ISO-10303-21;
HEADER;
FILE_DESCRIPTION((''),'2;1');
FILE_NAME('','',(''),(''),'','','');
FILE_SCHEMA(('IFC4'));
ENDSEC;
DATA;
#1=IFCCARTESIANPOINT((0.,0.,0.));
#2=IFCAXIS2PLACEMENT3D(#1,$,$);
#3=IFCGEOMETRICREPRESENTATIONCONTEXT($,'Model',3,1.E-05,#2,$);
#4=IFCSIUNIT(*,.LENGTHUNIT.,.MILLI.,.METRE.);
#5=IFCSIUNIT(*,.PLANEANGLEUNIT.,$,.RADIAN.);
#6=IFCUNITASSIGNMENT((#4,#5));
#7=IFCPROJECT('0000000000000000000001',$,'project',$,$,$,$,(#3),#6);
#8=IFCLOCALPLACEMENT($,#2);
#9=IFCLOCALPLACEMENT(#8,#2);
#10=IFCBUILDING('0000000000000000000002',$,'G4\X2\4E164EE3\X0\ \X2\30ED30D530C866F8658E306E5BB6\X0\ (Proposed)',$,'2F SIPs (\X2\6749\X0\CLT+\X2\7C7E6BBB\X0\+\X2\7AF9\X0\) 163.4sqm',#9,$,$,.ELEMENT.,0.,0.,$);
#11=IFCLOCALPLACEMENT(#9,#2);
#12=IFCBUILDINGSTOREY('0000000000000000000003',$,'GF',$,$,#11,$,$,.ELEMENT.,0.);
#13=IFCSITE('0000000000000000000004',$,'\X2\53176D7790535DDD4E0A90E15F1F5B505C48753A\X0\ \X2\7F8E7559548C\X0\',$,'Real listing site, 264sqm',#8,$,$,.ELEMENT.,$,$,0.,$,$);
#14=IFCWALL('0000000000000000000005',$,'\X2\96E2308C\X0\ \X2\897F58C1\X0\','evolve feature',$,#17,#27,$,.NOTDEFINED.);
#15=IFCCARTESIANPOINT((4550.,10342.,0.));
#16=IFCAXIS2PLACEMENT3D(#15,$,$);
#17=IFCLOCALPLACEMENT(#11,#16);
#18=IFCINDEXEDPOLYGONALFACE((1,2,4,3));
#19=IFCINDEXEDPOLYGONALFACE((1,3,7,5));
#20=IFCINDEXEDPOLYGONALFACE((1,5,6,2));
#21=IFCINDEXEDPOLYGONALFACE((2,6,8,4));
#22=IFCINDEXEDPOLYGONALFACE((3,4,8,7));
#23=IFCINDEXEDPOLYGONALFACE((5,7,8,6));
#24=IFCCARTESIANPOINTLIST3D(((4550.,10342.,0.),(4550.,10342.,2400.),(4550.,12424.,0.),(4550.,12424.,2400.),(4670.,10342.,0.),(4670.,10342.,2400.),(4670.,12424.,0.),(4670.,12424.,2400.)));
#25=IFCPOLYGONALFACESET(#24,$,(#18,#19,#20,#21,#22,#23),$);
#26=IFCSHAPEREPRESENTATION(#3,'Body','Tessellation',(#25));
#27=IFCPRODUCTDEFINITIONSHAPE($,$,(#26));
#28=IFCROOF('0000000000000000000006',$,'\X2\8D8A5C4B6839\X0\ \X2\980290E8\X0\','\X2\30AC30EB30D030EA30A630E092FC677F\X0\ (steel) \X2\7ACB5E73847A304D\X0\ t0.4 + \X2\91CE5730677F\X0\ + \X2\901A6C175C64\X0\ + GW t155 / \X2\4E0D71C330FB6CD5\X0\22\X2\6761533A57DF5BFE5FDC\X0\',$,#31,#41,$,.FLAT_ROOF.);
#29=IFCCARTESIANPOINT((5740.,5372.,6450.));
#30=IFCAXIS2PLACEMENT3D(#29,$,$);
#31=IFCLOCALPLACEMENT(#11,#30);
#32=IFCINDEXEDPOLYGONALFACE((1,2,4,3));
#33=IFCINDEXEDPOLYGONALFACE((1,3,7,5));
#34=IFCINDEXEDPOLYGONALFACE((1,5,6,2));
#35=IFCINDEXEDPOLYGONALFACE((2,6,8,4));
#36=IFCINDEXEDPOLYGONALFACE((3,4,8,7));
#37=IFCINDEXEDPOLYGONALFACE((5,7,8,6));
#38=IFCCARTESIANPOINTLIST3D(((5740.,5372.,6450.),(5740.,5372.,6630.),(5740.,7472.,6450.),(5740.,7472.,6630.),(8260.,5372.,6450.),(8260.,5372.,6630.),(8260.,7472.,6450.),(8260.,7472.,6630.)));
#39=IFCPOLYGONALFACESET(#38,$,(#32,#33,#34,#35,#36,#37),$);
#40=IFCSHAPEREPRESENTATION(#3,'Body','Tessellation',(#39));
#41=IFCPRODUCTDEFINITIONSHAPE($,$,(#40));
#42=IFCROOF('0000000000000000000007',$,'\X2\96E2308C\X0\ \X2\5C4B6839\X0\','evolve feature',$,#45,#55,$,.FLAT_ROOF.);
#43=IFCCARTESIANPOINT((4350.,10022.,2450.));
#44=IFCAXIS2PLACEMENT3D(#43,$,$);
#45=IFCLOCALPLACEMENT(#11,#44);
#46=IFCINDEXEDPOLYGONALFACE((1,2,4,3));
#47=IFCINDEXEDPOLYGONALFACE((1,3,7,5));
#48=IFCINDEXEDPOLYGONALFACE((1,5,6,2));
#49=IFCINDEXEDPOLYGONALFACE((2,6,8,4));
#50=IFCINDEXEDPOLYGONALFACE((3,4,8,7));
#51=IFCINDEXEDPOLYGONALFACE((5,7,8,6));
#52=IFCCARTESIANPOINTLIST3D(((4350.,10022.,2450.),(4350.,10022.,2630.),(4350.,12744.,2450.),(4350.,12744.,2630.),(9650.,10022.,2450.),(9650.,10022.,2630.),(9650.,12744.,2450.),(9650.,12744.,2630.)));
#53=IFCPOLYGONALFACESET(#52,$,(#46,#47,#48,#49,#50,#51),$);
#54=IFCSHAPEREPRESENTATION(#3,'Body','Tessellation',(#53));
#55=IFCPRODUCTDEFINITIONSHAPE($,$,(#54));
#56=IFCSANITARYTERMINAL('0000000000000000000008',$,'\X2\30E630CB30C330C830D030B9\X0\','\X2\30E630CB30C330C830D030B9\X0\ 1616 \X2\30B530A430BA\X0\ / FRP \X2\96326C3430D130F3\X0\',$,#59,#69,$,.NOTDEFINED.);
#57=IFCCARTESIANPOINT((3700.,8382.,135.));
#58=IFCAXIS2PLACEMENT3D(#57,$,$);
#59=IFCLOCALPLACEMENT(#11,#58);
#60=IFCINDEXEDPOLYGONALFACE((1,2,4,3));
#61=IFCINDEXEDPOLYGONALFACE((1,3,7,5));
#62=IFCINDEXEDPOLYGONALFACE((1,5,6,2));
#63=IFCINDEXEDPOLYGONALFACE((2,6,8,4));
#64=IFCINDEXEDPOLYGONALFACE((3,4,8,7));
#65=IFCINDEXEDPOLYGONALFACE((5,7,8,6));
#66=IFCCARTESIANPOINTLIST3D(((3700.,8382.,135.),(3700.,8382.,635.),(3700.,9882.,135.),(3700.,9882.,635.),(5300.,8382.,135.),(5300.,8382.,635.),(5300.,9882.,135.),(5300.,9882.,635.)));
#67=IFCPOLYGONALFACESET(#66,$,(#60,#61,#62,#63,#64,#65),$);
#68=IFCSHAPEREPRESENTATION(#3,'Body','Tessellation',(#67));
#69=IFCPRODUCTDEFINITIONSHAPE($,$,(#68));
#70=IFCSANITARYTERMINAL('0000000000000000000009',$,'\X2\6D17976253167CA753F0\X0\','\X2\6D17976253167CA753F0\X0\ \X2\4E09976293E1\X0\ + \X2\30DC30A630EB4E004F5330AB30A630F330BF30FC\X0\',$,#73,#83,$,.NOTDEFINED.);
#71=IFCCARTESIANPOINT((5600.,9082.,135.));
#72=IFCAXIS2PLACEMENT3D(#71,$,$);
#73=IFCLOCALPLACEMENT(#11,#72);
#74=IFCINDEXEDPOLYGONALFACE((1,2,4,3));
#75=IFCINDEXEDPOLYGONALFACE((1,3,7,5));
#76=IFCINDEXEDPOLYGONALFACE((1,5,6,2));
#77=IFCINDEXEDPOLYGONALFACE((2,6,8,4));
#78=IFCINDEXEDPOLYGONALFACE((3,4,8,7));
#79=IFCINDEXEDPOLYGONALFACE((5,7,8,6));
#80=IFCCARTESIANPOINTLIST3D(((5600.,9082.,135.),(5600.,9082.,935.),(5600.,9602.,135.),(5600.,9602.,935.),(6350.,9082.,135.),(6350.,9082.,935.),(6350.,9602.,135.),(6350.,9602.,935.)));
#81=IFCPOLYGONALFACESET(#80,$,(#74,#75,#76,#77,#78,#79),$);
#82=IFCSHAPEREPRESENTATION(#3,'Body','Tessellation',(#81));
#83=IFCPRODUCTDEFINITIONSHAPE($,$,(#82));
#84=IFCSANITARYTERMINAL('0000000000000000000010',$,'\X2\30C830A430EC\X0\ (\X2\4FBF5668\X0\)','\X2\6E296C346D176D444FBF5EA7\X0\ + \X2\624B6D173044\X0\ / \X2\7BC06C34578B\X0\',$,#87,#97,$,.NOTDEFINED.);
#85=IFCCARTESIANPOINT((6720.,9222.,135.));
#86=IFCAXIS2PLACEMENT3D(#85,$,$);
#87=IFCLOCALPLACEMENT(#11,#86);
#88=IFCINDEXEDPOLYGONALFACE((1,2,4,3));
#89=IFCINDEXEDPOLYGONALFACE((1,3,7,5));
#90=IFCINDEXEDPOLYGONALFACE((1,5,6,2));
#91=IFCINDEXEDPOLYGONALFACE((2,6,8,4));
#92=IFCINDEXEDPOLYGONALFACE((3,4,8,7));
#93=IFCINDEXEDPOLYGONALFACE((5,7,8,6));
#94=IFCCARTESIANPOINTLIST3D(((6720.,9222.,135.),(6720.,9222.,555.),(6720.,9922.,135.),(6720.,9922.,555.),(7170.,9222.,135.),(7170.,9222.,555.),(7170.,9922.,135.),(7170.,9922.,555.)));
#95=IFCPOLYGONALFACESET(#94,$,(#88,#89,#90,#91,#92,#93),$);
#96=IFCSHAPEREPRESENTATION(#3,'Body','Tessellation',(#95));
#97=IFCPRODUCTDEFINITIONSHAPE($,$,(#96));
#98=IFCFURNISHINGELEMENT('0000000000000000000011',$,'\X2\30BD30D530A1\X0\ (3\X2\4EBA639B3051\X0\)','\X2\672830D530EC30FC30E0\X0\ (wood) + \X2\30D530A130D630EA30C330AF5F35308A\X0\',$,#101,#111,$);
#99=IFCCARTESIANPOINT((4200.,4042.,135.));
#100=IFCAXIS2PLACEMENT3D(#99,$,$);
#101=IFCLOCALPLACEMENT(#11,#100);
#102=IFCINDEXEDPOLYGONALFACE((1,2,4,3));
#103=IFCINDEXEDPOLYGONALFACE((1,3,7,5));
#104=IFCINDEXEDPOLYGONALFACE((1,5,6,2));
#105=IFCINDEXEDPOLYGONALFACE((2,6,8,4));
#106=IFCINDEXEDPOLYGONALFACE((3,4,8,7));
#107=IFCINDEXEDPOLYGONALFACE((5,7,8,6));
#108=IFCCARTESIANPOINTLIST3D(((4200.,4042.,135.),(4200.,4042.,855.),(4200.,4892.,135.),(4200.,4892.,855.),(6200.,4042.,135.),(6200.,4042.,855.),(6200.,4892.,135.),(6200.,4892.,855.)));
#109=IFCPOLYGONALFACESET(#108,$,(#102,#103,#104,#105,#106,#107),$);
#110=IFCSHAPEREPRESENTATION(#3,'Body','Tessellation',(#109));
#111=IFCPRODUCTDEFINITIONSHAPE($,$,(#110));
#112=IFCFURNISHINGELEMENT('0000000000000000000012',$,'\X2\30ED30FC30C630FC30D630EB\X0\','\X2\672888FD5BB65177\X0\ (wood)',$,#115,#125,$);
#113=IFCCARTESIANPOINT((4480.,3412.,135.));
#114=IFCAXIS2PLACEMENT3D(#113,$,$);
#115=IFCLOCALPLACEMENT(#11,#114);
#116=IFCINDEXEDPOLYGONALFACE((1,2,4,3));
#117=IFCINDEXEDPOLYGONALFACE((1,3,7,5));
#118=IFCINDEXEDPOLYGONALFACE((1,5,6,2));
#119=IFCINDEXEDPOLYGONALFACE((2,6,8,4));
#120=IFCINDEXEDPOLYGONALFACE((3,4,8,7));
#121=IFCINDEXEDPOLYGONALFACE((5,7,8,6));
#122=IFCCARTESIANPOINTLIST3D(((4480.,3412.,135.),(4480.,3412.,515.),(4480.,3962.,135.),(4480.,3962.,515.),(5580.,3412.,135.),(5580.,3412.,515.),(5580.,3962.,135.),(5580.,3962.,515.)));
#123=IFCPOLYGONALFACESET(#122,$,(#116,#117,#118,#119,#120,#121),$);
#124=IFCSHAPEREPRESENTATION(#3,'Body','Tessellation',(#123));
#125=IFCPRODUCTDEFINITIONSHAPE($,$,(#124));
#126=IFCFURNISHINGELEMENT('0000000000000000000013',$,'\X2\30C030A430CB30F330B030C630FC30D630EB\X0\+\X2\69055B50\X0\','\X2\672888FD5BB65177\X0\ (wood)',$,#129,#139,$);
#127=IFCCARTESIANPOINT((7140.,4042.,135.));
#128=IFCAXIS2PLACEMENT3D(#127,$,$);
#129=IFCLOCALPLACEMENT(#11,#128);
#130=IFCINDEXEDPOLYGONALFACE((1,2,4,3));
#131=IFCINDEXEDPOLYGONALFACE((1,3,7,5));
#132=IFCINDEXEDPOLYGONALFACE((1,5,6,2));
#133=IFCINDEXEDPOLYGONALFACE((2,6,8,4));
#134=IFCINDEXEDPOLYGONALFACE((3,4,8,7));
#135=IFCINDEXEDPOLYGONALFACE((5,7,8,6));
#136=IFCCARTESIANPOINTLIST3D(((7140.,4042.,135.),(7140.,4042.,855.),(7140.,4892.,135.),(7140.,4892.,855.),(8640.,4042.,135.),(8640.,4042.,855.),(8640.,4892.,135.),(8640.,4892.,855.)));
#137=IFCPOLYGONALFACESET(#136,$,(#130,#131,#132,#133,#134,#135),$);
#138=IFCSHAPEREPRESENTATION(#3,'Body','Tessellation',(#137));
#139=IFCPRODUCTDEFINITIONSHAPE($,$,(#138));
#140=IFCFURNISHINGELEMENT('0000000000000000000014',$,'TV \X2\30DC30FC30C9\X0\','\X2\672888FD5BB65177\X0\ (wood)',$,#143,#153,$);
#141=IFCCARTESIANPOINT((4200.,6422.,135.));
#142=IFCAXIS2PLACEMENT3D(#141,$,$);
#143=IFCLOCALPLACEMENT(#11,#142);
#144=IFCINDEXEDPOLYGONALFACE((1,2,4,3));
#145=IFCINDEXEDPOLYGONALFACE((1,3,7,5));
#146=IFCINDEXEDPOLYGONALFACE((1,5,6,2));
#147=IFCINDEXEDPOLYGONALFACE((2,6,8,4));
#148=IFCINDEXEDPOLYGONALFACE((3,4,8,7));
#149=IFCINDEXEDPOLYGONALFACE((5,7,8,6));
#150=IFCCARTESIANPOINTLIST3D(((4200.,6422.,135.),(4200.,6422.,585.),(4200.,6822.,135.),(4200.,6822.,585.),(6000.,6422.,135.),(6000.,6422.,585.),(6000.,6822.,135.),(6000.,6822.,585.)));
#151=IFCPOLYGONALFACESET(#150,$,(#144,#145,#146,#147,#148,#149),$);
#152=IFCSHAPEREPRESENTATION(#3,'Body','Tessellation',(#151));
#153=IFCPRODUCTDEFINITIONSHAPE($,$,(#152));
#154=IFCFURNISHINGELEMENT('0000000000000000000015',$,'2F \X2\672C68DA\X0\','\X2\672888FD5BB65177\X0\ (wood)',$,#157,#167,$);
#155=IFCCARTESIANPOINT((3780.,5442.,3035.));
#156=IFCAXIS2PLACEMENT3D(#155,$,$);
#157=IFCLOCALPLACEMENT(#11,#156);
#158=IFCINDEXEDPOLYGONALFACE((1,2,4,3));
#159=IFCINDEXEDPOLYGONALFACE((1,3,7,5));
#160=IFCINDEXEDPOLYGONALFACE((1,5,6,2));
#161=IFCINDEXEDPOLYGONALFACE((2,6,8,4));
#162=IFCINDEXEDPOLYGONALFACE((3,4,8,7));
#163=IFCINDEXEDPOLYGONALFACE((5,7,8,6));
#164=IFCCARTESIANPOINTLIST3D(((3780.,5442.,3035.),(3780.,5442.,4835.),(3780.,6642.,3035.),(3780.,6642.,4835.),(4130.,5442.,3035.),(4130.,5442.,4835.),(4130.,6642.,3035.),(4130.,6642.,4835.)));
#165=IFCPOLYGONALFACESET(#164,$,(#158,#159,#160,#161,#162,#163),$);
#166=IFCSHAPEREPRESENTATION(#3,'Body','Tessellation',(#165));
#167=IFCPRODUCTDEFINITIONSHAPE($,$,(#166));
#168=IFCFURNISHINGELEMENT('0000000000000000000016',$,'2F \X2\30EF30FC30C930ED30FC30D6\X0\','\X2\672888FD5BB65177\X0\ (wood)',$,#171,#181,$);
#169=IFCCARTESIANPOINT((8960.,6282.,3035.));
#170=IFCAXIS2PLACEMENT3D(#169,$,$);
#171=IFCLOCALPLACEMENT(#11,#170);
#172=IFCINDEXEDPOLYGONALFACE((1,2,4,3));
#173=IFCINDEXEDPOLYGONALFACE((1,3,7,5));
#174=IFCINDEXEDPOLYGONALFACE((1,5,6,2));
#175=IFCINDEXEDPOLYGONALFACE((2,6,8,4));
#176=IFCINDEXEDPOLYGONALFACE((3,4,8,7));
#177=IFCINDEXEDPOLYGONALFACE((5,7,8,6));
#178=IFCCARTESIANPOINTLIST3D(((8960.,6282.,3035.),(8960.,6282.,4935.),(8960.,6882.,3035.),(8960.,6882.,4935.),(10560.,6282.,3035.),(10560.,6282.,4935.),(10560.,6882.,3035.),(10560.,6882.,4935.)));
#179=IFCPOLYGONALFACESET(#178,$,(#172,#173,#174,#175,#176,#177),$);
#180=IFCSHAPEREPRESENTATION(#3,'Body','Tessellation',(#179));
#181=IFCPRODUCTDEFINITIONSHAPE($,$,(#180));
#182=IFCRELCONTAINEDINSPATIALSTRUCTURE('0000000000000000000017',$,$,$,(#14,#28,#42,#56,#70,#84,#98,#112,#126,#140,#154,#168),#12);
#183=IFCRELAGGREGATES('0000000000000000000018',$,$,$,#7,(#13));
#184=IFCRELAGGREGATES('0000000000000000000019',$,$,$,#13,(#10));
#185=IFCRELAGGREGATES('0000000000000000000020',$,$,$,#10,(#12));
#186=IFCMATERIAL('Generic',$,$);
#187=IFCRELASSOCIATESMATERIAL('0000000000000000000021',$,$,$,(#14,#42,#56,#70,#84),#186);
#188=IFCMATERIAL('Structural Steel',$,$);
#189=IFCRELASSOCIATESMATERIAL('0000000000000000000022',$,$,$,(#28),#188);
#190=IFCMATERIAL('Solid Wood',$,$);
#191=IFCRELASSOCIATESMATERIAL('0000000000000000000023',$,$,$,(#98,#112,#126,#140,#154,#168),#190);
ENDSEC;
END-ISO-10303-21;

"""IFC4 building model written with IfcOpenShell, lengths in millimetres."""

from ifc_helpers import new_model, si_unit, frame, frame_2d, origin, place, context, project, spatial, rectangle, extrude, material, element, save


model = new_model("IFC4")

# Units and contexts
model_context = context("Model", 3, precision=1e-05, world=origin())
ifc_project = project(units=[si_unit("LENGTHUNIT", "METRE", prefix="MILLI"), si_unit("PLANEANGLEUNIT", "RADIAN")], contexts=[model_context])

# Site, building, storey
site_placement = place(None, origin())
site = spatial("IfcSite", under=ifc_project, at=site_placement, Name="北海道川上郡弟子屈町 美留和", ObjectType="Real listing site, 264sqm", CompositionType="ELEMENT", RefElevation=0.0)
building_placement = place(site_placement, origin())
building = spatial("IfcBuilding", under=site, at=building_placement, Name="G4世代 ロフト書斎の家 (Proposed)", ObjectType="2F SIPs (杉CLT+籾殻+竹) 163.4sqm", CompositionType="ELEMENT", ElevationOfRefHeight=0.0, ElevationOfTerrain=0.0)
storey_placement = place(building_placement, origin())
storey = spatial("IfcBuildingStorey", under=building, at=storey_placement, Name="GF", CompositionType="ELEMENT", Elevation=0.0)

# Shared definitions
ifc_material_1 = material(Name="Generic")

# Shared definitions
ifc_material_2 = material(Name="Solid Wood")

# Wall
wall_1_placement = place(storey_placement, frame((4550.0, 10342.0, 0.0)))
element("IfcWall", 1, at=wall_1_placement, inside=storey, material=ifc_material_1, Name="離れ 西壁", Description="evolve feature", PredefinedType="NOTDEFINED", context=model_context, shape_type="SweptSolid", body=[
    extrude(rectangle(XDim=120.0, YDim=2082.0, at=frame_2d((60.0, 1041.0))), frame((4550.0, 10342.0, 0.0)), (0.0, 0.0, 1.0), 2400.0),
])

# Roofs
ifc_material_3 = material(Name="Structural Steel")
roof_1_placement = place(storey_placement, frame((5740.0, 5372.0, 6450.0)))
element("IfcRoof", 2, at=roof_1_placement, inside=storey, material=ifc_material_3, Name="越屋根 頂部", Description="ガルバリウム鋼板 (steel) 立平葺き t0.4 + 野地板 + 通気層 + GW t155 / 不燃・法22条区域対応", PredefinedType="FLAT_ROOF", context=model_context, shape_type="SweptSolid", body=[
    extrude(rectangle(XDim=2520.0, YDim=2100.0, at=frame_2d((1260.0, 1050.0))), frame((5740.0, 5372.0, 6450.0)), (0.0, 0.0, 1.0), 180.0),
])
roof_2_placement = place(storey_placement, frame((4350.0, 10022.0, 2450.0)))
element("IfcRoof", 3, at=roof_2_placement, inside=storey, material=ifc_material_1, Name="離れ 屋根", Description="evolve feature", PredefinedType="FLAT_ROOF", context=model_context, shape_type="SweptSolid", body=[
    extrude(rectangle(XDim=5300.0, YDim=2722.0, at=frame_2d((2650.0, 1361.0))), frame((4350.0, 10022.0, 2450.0)), (0.0, 0.0, 1.0), 180.0),
])

# Sanitary terminals
sanitary_terminal_1_placement = place(storey_placement, frame((3700.0, 8382.0, 135.0)))
element("IfcSanitaryTerminal", 4, at=sanitary_terminal_1_placement, inside=storey, material=ifc_material_1, Name="ユニットバス", Description="ユニットバス 1616 サイズ / FRP 防水パン", PredefinedType="NOTDEFINED", context=model_context, shape_type="SweptSolid", body=[
    extrude(rectangle(XDim=1600.0, YDim=1500.0, at=frame_2d((800.0, 750.0))), frame((3700.0, 8382.0, 135.0)), (0.0, 0.0, 1.0), 500.0),
])
sanitary_terminal_2_placement = place(storey_placement, frame((5600.0, 9082.0, 135.0)))
element("IfcSanitaryTerminal", 5, at=sanitary_terminal_2_placement, inside=storey, material=ifc_material_1, Name="洗面化粧台", Description="洗面化粧台 三面鏡 + ボウル一体カウンター", PredefinedType="NOTDEFINED", context=model_context, shape_type="SweptSolid", body=[
    extrude(rectangle(XDim=750.0, YDim=520.0, at=frame_2d((375.0, 260.0))), frame((5600.0, 9082.0, 135.0)), (0.0, 0.0, 1.0), 800.0),
])
sanitary_terminal_3_placement = place(storey_placement, frame((6720.0, 9222.0, 135.0)))
element("IfcSanitaryTerminal", 6, at=sanitary_terminal_3_placement, inside=storey, material=ifc_material_1, Name="トイレ (便器)", Description="温水洗浄便座 + 手洗い / 節水型", PredefinedType="NOTDEFINED", context=model_context, shape_type="SweptSolid", body=[
    extrude(rectangle(XDim=450.0, YDim=700.0, at=frame_2d((225.0, 350.0))), frame((6720.0, 9222.0, 135.0)), (0.0, 0.0, 1.0), 420.0),
])

# Furnishing elements
furnishing_1_placement = place(storey_placement, frame((4200.0, 4042.0, 135.0)))
element("IfcFurnishingElement", 7, at=furnishing_1_placement, inside=storey, material=ifc_material_2, Name="ソファ (3人掛け)", Description="木フレーム (wood) + ファブリック張り", context=model_context, shape_type="SweptSolid", body=[
    extrude(rectangle(XDim=2000.0, YDim=850.0, at=frame_2d((1000.0, 425.0))), frame((4200.0, 4042.0, 135.0)), (0.0, 0.0, 1.0), 720.0),
])
furnishing_2_placement = place(storey_placement, frame((4480.0, 3412.0, 135.0)))
element("IfcFurnishingElement", 8, at=furnishing_2_placement, inside=storey, material=ifc_material_2, Name="ローテーブル", Description="木製家具 (wood)", context=model_context, shape_type="SweptSolid", body=[
    extrude(rectangle(XDim=1100.0, YDim=550.0, at=frame_2d((550.0, 275.0))), frame((4480.0, 3412.0, 135.0)), (0.0, 0.0, 1.0), 380.0),
])
furnishing_3_placement = place(storey_placement, frame((7140.0, 4042.0, 135.0)))
element("IfcFurnishingElement", 9, at=furnishing_3_placement, inside=storey, material=ifc_material_2, Name="ダイニングテーブル+椅子", Description="木製家具 (wood)", context=model_context, shape_type="SweptSolid", body=[
    extrude(rectangle(XDim=1500.0, YDim=850.0, at=frame_2d((750.0, 425.0))), frame((7140.0, 4042.0, 135.0)), (0.0, 0.0, 1.0), 720.0),
])
furnishing_4_placement = place(storey_placement, frame((4200.0, 6422.0, 135.0)))
element("IfcFurnishingElement", 10, at=furnishing_4_placement, inside=storey, material=ifc_material_2, Name="TV ボード", Description="木製家具 (wood)", context=model_context, shape_type="SweptSolid", body=[
    extrude(rectangle(XDim=1800.0, YDim=400.0, at=frame_2d((900.0, 200.0))), frame((4200.0, 6422.0, 135.0)), (0.0, 0.0, 1.0), 450.0),
])
furnishing_5_placement = place(storey_placement, frame((3780.0, 5442.0, 3035.0)))
element("IfcFurnishingElement", 11, at=furnishing_5_placement, inside=storey, material=ifc_material_2, Name="2F 本棚", Description="木製家具 (wood)", context=model_context, shape_type="SweptSolid", body=[
    extrude(rectangle(XDim=350.0, YDim=1200.0, at=frame_2d((175.0, 600.0))), frame((3780.0, 5442.0, 3035.0)), (0.0, 0.0, 1.0), 1800.0),
])
furnishing_6_placement = place(storey_placement, frame((8960.0, 6282.0, 3035.0)))
element("IfcFurnishingElement", 12, at=furnishing_6_placement, inside=storey, material=ifc_material_2, Name="2F ワードローブ", Description="木製家具 (wood)", context=model_context, shape_type="SweptSolid", body=[
    extrude(rectangle(XDim=1600.0, YDim=600.0, at=frame_2d((800.0, 300.0))), frame((8960.0, 6282.0, 3035.0)), (0.0, 0.0, 1.0), 1900.0),
])

save(model, "model.ifc")
